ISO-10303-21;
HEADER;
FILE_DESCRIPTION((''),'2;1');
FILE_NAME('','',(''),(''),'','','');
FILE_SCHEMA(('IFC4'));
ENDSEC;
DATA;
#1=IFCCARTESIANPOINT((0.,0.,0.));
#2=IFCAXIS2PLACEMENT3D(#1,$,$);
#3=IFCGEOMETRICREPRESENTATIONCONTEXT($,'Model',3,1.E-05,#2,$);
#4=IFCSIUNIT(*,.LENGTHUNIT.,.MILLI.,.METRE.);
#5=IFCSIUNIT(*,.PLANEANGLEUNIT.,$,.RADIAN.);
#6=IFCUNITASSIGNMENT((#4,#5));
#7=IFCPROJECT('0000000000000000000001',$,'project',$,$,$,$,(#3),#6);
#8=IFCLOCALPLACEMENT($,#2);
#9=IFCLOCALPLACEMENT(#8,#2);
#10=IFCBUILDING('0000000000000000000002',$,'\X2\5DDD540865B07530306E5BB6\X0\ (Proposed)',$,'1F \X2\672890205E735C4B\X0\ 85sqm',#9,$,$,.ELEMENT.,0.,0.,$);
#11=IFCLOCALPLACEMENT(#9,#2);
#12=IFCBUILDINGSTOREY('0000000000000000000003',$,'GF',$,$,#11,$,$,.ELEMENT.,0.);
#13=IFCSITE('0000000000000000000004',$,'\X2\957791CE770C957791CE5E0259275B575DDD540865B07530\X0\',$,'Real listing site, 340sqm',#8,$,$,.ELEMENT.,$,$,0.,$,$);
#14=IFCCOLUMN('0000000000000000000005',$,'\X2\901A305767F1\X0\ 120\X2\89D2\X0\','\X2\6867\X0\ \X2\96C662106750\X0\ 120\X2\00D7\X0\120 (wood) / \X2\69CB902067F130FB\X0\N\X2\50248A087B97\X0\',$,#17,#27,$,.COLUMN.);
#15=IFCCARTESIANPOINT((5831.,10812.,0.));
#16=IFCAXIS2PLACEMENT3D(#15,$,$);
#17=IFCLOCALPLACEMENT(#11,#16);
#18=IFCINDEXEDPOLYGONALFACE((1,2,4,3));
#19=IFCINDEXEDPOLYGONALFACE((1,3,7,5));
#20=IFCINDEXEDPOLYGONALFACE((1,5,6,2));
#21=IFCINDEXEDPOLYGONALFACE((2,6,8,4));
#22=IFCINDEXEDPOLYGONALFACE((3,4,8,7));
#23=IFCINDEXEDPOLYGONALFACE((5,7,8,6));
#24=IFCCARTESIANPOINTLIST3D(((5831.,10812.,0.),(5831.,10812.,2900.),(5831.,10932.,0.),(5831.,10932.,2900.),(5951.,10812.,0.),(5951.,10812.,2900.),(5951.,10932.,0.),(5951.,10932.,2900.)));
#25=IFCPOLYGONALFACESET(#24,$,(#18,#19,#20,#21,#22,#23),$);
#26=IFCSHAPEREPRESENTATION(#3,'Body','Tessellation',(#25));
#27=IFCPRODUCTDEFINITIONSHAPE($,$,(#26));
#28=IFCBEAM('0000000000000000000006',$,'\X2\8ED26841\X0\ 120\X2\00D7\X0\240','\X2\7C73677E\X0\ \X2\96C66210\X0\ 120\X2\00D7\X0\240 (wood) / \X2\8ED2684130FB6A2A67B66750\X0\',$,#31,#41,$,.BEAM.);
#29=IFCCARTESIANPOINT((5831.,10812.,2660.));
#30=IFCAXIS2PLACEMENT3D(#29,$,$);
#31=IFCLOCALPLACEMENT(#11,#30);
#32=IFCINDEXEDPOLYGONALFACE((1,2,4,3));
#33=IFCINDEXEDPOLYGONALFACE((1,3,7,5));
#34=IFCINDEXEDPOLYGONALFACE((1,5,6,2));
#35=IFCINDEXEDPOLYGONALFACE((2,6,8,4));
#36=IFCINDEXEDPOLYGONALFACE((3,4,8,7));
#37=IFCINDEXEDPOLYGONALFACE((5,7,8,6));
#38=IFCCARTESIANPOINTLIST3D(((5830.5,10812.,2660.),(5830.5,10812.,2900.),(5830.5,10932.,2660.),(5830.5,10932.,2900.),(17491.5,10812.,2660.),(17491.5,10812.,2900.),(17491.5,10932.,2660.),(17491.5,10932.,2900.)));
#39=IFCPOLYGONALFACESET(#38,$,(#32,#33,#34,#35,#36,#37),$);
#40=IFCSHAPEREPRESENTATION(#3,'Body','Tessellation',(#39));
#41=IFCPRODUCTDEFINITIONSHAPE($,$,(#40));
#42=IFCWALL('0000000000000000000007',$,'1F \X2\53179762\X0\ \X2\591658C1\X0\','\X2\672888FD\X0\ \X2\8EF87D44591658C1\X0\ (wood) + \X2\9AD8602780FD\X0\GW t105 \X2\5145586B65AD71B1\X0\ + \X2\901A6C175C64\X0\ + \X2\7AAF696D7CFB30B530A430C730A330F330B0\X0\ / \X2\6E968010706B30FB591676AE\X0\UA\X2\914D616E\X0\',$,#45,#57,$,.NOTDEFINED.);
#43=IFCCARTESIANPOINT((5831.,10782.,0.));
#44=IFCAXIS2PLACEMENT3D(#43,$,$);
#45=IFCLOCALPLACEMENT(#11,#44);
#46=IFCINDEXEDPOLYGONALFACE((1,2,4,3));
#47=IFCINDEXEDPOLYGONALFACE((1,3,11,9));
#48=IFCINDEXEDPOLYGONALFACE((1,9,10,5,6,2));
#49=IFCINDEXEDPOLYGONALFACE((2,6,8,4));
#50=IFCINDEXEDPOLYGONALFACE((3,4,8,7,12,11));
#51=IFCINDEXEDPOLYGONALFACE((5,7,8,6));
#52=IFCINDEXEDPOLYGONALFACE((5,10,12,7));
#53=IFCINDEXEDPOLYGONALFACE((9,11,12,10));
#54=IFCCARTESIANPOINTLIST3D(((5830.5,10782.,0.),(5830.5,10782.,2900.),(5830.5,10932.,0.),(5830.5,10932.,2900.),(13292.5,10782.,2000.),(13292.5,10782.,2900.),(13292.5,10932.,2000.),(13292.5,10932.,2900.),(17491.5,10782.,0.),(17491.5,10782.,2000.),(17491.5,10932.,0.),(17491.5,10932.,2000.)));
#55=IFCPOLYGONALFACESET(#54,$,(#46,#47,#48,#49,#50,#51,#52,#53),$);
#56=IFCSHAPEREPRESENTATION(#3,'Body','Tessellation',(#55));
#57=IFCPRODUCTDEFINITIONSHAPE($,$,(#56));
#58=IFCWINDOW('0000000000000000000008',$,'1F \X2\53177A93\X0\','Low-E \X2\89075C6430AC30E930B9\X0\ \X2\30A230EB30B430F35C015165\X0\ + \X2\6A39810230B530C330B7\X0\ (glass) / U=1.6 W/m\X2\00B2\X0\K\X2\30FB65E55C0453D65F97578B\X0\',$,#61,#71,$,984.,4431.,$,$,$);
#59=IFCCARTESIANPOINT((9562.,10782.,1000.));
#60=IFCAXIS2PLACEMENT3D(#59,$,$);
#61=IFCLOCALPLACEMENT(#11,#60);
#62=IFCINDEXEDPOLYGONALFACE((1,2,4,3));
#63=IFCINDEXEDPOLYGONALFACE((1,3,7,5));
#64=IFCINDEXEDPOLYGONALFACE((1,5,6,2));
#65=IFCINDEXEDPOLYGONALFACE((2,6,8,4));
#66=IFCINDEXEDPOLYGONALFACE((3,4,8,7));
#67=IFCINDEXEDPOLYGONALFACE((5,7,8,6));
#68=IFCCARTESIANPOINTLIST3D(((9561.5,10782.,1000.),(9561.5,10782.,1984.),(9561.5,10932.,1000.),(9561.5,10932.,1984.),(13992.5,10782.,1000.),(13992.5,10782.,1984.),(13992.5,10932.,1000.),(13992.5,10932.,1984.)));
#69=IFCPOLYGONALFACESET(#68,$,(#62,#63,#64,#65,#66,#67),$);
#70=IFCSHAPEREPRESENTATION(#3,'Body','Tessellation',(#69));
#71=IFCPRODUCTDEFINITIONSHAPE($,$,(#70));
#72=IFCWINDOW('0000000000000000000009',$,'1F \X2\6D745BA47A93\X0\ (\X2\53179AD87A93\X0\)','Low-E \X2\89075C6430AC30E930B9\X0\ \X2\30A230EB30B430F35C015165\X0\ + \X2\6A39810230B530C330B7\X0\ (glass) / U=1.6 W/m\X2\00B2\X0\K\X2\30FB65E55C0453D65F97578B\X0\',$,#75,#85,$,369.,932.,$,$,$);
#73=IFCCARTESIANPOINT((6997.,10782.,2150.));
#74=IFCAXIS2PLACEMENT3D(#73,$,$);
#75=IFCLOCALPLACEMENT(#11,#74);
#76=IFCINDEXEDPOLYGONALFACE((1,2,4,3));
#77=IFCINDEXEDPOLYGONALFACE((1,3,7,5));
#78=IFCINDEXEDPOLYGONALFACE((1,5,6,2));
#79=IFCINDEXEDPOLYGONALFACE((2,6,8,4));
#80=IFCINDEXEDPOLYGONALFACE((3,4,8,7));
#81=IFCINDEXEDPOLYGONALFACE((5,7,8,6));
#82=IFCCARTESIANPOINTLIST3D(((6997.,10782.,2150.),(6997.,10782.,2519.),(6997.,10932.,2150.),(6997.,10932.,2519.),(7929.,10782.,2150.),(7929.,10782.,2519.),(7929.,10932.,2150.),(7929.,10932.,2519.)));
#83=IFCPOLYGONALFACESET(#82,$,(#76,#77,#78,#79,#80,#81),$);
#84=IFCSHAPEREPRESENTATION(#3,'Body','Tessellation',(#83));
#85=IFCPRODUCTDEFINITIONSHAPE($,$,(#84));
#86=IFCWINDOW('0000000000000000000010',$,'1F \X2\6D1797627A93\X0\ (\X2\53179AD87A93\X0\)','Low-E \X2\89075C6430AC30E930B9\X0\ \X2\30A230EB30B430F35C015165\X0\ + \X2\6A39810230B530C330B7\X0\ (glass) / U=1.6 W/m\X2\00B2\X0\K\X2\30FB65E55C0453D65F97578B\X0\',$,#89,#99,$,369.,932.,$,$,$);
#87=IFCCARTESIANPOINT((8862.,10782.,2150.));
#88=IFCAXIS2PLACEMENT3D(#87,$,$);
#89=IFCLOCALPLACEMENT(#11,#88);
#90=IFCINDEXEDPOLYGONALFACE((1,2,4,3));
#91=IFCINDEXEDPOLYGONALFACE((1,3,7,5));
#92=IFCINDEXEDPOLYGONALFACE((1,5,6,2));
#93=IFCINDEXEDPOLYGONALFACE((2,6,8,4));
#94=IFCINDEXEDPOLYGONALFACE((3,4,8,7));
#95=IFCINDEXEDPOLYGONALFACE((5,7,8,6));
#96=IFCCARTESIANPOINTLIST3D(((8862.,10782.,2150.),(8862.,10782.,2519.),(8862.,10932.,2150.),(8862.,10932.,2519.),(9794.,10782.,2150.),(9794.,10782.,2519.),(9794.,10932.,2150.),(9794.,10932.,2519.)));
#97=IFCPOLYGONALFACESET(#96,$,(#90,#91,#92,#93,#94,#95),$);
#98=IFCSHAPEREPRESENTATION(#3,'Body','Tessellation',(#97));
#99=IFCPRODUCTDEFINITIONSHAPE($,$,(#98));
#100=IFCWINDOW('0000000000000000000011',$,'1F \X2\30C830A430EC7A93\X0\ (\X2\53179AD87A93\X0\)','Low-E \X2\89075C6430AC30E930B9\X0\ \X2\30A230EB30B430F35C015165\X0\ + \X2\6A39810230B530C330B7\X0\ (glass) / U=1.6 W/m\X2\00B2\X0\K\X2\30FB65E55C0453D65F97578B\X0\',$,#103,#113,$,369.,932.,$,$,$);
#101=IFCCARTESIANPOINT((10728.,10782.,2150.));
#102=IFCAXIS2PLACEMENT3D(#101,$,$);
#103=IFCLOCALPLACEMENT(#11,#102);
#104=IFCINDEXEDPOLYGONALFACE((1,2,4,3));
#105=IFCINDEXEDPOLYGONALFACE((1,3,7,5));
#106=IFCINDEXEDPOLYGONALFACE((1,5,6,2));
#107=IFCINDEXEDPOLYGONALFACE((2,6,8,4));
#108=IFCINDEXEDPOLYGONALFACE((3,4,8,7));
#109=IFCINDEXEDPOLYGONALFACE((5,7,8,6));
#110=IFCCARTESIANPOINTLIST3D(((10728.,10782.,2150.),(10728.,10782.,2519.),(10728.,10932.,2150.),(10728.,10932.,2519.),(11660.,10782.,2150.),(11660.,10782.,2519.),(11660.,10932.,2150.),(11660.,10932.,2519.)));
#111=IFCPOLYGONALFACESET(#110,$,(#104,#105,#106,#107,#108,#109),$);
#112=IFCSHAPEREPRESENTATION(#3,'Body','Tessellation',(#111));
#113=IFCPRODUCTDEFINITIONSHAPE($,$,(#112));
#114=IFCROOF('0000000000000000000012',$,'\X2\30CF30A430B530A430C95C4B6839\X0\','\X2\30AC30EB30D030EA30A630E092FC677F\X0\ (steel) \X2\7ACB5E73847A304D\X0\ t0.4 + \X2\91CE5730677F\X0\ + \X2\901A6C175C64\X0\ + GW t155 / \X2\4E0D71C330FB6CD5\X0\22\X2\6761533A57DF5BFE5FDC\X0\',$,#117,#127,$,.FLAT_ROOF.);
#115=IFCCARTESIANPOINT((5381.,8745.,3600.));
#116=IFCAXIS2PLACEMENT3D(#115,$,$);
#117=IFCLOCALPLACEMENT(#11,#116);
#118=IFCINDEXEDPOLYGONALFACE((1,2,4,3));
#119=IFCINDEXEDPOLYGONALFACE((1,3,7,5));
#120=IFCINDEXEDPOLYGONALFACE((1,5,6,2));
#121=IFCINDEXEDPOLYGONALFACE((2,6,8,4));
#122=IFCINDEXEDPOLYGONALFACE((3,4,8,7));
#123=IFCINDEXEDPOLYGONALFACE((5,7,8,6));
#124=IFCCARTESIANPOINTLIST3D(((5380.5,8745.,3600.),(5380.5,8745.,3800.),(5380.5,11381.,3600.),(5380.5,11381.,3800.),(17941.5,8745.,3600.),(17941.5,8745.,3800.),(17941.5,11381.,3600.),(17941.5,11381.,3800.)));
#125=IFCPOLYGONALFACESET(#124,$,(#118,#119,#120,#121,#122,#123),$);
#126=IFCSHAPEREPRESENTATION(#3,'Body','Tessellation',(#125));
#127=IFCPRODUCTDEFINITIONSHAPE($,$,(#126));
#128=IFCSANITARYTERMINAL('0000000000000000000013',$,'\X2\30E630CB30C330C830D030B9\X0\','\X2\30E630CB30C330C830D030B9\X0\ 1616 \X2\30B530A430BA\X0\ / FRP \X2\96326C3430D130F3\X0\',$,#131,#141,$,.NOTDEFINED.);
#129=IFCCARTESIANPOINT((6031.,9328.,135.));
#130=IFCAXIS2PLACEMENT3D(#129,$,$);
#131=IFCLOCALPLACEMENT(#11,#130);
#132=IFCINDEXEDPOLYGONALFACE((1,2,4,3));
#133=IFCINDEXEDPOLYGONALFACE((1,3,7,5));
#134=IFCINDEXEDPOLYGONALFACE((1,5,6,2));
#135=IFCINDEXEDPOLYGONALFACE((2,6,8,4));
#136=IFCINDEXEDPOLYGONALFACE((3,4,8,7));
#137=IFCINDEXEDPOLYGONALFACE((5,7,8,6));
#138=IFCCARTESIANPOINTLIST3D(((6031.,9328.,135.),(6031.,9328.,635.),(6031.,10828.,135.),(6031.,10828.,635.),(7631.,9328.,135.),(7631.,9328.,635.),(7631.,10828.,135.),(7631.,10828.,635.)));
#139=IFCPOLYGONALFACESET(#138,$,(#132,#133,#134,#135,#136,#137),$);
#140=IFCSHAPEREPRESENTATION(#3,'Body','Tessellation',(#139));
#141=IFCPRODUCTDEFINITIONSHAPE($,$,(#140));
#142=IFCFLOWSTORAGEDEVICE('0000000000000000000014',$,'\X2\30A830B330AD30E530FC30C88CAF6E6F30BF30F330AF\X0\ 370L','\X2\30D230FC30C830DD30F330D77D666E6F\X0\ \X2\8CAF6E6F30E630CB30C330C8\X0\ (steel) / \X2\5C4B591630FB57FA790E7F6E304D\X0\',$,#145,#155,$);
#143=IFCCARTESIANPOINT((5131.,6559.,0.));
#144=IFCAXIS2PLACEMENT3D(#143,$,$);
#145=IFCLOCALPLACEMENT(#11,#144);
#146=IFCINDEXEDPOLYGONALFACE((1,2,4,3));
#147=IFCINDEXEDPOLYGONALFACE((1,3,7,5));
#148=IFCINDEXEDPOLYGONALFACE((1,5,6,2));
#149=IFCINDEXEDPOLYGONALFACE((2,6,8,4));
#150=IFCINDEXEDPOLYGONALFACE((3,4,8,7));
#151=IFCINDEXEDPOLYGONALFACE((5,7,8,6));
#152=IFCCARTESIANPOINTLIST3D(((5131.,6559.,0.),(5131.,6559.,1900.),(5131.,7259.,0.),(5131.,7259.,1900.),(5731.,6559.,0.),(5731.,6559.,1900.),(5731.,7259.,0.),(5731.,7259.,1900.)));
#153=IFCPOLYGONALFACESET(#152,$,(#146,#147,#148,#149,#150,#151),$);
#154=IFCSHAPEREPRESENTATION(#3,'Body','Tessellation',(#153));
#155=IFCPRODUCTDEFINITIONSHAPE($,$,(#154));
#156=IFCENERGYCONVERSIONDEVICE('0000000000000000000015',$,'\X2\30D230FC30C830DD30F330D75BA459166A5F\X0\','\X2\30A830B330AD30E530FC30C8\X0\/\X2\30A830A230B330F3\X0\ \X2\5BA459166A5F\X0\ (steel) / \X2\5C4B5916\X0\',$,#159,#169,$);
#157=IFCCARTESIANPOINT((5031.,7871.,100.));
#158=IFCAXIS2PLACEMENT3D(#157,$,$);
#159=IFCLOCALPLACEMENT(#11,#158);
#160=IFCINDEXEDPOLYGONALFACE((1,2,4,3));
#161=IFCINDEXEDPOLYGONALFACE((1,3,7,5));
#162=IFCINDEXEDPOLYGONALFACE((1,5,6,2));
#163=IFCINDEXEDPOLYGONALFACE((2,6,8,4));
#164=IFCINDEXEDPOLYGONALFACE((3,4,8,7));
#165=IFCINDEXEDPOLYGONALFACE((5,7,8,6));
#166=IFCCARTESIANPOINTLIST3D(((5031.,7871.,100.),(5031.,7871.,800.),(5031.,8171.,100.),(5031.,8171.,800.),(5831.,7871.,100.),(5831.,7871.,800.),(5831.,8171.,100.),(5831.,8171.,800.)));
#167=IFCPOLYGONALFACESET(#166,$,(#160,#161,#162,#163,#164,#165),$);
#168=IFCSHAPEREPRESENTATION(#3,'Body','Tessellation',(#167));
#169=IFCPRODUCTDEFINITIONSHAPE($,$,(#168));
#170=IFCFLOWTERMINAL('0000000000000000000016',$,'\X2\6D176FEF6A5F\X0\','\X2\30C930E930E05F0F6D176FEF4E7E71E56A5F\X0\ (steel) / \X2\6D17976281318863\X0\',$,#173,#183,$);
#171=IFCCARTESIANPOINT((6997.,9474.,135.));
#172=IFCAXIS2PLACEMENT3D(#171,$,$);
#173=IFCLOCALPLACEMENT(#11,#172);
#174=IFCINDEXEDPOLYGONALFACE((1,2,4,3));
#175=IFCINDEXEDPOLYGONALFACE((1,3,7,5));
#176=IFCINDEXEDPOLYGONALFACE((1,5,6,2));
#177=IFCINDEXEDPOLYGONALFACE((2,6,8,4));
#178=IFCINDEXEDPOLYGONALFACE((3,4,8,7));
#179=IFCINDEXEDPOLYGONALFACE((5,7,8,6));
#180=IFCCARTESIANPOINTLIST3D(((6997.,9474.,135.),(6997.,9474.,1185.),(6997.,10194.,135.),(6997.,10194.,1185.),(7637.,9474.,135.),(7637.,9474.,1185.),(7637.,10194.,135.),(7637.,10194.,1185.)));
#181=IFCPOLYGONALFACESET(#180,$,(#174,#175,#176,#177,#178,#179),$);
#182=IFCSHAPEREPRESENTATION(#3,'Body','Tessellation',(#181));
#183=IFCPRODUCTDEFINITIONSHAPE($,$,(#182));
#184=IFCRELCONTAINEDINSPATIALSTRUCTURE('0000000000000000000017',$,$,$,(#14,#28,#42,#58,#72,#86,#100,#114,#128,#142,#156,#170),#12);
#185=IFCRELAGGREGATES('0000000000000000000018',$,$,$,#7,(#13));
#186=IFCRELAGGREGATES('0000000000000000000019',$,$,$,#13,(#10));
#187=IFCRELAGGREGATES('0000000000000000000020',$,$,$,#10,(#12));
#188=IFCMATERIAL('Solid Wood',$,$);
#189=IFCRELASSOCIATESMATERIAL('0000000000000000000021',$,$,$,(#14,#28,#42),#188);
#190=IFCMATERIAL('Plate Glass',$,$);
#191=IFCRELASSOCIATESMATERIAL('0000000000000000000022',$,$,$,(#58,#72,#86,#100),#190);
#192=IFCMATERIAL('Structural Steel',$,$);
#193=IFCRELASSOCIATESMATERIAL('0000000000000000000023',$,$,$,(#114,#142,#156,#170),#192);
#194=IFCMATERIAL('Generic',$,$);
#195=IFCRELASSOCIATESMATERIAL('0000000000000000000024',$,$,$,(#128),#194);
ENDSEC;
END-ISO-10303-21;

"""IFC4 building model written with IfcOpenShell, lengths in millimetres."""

from ifc_helpers import new_model, si_unit, frame, frame_2d, origin, place, context, project, spatial, rectangle, extrude, material, element, fill, save


model = new_model("IFC4")

# Units and contexts
model_context = context("Model", 3, precision=1e-05, world=origin())
ifc_project = project(units=[si_unit("LENGTHUNIT", "METRE", prefix="MILLI"), si_unit("PLANEANGLEUNIT", "RADIAN")], contexts=[model_context])

# Site, building, storey
site_placement = place(None, origin())
site = spatial("IfcSite", under=ifc_project, at=site_placement, Name="長野県長野市大字川合新田", ObjectType="Real listing site, 340sqm", CompositionType="ELEMENT", RefElevation=0.0)
building_placement = place(site_placement, origin())
building = spatial("IfcBuilding", under=site, at=building_placement, Name="川合新田の家 (Proposed)", ObjectType="1F 木造平屋 85sqm", CompositionType="ELEMENT", ElevationOfRefHeight=0.0, ElevationOfTerrain=0.0)
storey_placement = place(building_placement, origin())
storey = spatial("IfcBuildingStorey", under=building, at=storey_placement, Name="GF", CompositionType="ELEMENT", Elevation=0.0)

# Column
ifc_material_1 = material(Name="Solid Wood")
column_1_placement = place(storey_placement, frame((5831.0, 10812.0, 0.0)))
element("IfcColumn", 1, at=column_1_placement, inside=storey, material=ifc_material_1, Name="通し柱 120角", Description="桧 集成材 120×120 (wood) / 構造柱・N値計算", PredefinedType="COLUMN", context=model_context, shape_type="SweptSolid", body=[
    extrude(rectangle(XDim=120.0, YDim=120.0, at=frame_2d((60.0, 60.0))), frame((5831.0, 10812.0, 0.0)), (0.0, 0.0, 1.0), 2900.0),
])

# Beam
beam_1_placement = place(storey_placement, frame((5831.0, 10812.0, 2660.0)))
element("IfcBeam", 2, at=beam_1_placement, inside=storey, material=ifc_material_1, Name="軒桁 120×240", Description="米松 集成 120×240 (wood) / 軒桁・横架材", PredefinedType="BEAM", context=model_context, shape_type="SweptSolid", body=[
    extrude(rectangle(XDim=11661.0, YDim=120.0, at=frame_2d((5830.0, 60.0))), frame((5831.0, 10812.0, 2660.0)), (0.0, 0.0, 1.0), 240.0),
])

# Wall, openings, windows
wall_1_placement = place(storey_placement, frame((5831.0, 10782.0, 0.0)))
wall_1 = element("IfcWall", 3, at=wall_1_placement, inside=storey, material=ifc_material_1, Name="1F 北面 外壁", Description="木製 軸組外壁 (wood) + 高性能GW t105 充填断熱 + 通気層 + 窯業系サイディング / 準耐火・外皮UA配慮", PredefinedType="NOTDEFINED", context=model_context, shape_type="SweptSolid", body=[
    extrude(rectangle(XDim=11661.0, YDim=150.0, at=frame_2d((5830.0, 75.0))), frame((5831.0, 10782.0, 0.0)), (0.0, 0.0, 1.0), 2900.0),
])
opening_1_placement = place(storey_placement, frame((9562.0, 10782.0, 1000.0)))
opening_1 = element("IfcOpeningElement", 4, at=opening_1_placement, cuts=wall_1, PredefinedType="NOTDEFINED", context=model_context, shape_type="SweptSolid", body=[
    extrude(rectangle(XDim=4431.0, YDim=150.0, at=frame_2d((2215.0, 75.0))), frame((9562.0, 10782.0, 1000.0)), (0.0, 0.0, 1.0), 984.0),
])
opening_2_placement = place(storey_placement, frame((6997.0, 10782.0, 2150.0)))
opening_2 = element("IfcOpeningElement", 5, at=opening_2_placement, cuts=wall_1, PredefinedType="NOTDEFINED", context=model_context, shape_type="SweptSolid", body=[
    extrude(rectangle(XDim=932.0, YDim=150.0, at=frame_2d((466.0, 75.0))), frame((6997.0, 10782.0, 2150.0)), (0.0, 0.0, 1.0), 369.0),
])
opening_3_placement = place(storey_placement, frame((8862.0, 10782.0, 2150.0)))
opening_3 = element("IfcOpeningElement", 6, at=opening_3_placement, cuts=wall_1, PredefinedType="NOTDEFINED", context=model_context, shape_type="SweptSolid", body=[
    extrude(rectangle(XDim=932.0, YDim=150.0, at=frame_2d((466.0, 75.0))), frame((8862.0, 10782.0, 2150.0)), (0.0, 0.0, 1.0), 369.0),
])
opening_4_placement = place(storey_placement, frame((10728.0, 10782.0, 2150.0)))
opening_4 = element("IfcOpeningElement", 7, at=opening_4_placement, cuts=wall_1, PredefinedType="NOTDEFINED", context=model_context, shape_type="SweptSolid", body=[
    extrude(rectangle(XDim=932.0, YDim=150.0, at=frame_2d((466.0, 75.0))), frame((10728.0, 10782.0, 2150.0)), (0.0, 0.0, 1.0), 369.0),
])
ifc_material_2 = material(Name="Plate Glass")
window_1_placement = place(storey_placement, frame((9562.0, 10782.0, 1000.0)))
window_1 = element("IfcWindow", 8, at=window_1_placement, inside=storey, material=ifc_material_2, Name="1F 北窓", Description="Low-E 複層ガラス アルゴン封入 + 樹脂サッシ (glass) / U=1.6 W/m²K・日射取得型", OverallHeight=984.0, OverallWidth=4431.0, context=model_context, shape_type="SweptSolid", body=[
    extrude(rectangle(XDim=4431.0, YDim=150.0, at=frame_2d((2215.0, 75.0))), frame((9562.0, 10782.0, 1000.0)), (0.0, 0.0, 1.0), 984.0),
])
fill(opening_1, window_1)
window_2_placement = place(storey_placement, frame((6997.0, 10782.0, 2150.0)))
window_2 = element("IfcWindow", 9, at=window_2_placement, inside=storey, material=ifc_material_2, Name="1F 浴室窓 (北高窓)", Description="Low-E 複層ガラス アルゴン封入 + 樹脂サッシ (glass) / U=1.6 W/m²K・日射取得型", OverallHeight=369.0, OverallWidth=932.0, context=model_context, shape_type="SweptSolid", body=[
    extrude(rectangle(XDim=932.0, YDim=150.0, at=frame_2d((466.0, 75.0))), frame((6997.0, 10782.0, 2150.0)), (0.0, 0.0, 1.0), 369.0),
])
fill(opening_2, window_2)
window_3_placement = place(storey_placement, frame((8862.0, 10782.0, 2150.0)))
window_3 = element("IfcWindow", 10, at=window_3_placement, inside=storey, material=ifc_material_2, Name="1F 洗面窓 (北高窓)", Description="Low-E 複層ガラス アルゴン封入 + 樹脂サッシ (glass) / U=1.6 W/m²K・日射取得型", OverallHeight=369.0, OverallWidth=932.0, context=model_context, shape_type="SweptSolid", body=[
    extrude(rectangle(XDim=932.0, YDim=150.0, at=frame_2d((466.0, 75.0))), frame((8862.0, 10782.0, 2150.0)), (0.0, 0.0, 1.0), 369.0),
])
fill(opening_3, window_3)
window_4_placement = place(storey_placement, frame((10728.0, 10782.0, 2150.0)))
window_4 = element("IfcWindow", 11, at=window_4_placement, inside=storey, material=ifc_material_2, Name="1F トイレ窓 (北高窓)", Description="Low-E 複層ガラス アルゴン封入 + 樹脂サッシ (glass) / U=1.6 W/m²K・日射取得型", OverallHeight=369.0, OverallWidth=932.0, context=model_context, shape_type="SweptSolid", body=[
    extrude(rectangle(XDim=932.0, YDim=150.0, at=frame_2d((466.0, 75.0))), frame((10728.0, 10782.0, 2150.0)), (0.0, 0.0, 1.0), 369.0),
])
fill(opening_4, window_4)

# Roof
ifc_material_3 = material(Name="Structural Steel")
roof_placement = place(storey_placement, frame((5381.0, 8745.0, 3600.0)))
element("IfcRoof", 12, at=roof_placement, inside=storey, material=ifc_material_3, Name="ハイサイド屋根", Description="ガルバリウム鋼板 (steel) 立平葺き t0.4 + 野地板 + 通気層 + GW t155 / 不燃・法22条区域対応", PredefinedType="FLAT_ROOF", context=model_context, shape_type="SweptSolid", body=[
    extrude(rectangle(XDim=12561.0, YDim=2636.0, at=frame_2d((6280.0, 1318.0))), frame((5381.0, 8745.0, 3600.0)), (0.0, 0.0, 1.0), 200.0),
])

# Sanitary terminal
ifc_material_4 = material(Name="Generic")
sanitary_terminal_placement = place(storey_placement, frame((6031.0, 9328.0, 135.0)))
element("IfcSanitaryTerminal", 13, at=sanitary_terminal_placement, inside=storey, material=ifc_material_4, Name="ユニットバス", Description="ユニットバス 1616 サイズ / FRP 防水パン", PredefinedType="NOTDEFINED", context=model_context, shape_type="SweptSolid", body=[
    extrude(rectangle(XDim=1600.0, YDim=1500.0, at=frame_2d((800.0, 750.0))), frame((6031.0, 9328.0, 135.0)), (0.0, 0.0, 1.0), 500.0),
])

# Flow storage device
flow_storage_device_placement = place(storey_placement, frame((5131.0, 6559.0, 0.0)))
element("IfcFlowStorageDevice", 14, at=flow_storage_device_placement, inside=storey, material=ifc_material_3, Name="エコキュート貯湯タンク 370L", Description="ヒートポンプ給湯 貯湯ユニット (steel) / 屋外・基礎置き", context=model_context, shape_type="SweptSolid", body=[
    extrude(rectangle(XDim=600.0, YDim=700.0, at=frame_2d((300.0, 350.0))), frame((5131.0, 6559.0, 0.0)), (0.0, 0.0, 1.0), 1900.0),
])

# Energy conversion device
energy_conversion_device_placement = place(storey_placement, frame((5031.0, 7871.0, 100.0)))
element("IfcEnergyConversionDevice", 15, at=energy_conversion_device_placement, inside=storey, material=ifc_material_3, Name="ヒートポンプ室外機", Description="エコキュート/エアコン 室外機 (steel) / 屋外", context=model_context, shape_type="SweptSolid", body=[
    extrude(rectangle(XDim=800.0, YDim=300.0, at=frame_2d((400.0, 150.0))), frame((5031.0, 7871.0, 100.0)), (0.0, 0.0, 1.0), 700.0),
])

# Flow terminal
flow_terminal_placement = place(storey_placement, frame((6997.0, 9474.0, 135.0)))
element("IfcFlowTerminal", 16, at=flow_terminal_placement, inside=storey, material=ifc_material_3, Name="洗濯機", Description="ドラム式洗濯乾燥機 (steel) / 洗面脱衣", context=model_context, shape_type="SweptSolid", body=[
    extrude(rectangle(XDim=640.0, YDim=720.0, at=frame_2d((320.0, 360.0))), frame((6997.0, 9474.0, 135.0)), (0.0, 0.0, 1.0), 1050.0),
])

save(model, "model.ifc")
